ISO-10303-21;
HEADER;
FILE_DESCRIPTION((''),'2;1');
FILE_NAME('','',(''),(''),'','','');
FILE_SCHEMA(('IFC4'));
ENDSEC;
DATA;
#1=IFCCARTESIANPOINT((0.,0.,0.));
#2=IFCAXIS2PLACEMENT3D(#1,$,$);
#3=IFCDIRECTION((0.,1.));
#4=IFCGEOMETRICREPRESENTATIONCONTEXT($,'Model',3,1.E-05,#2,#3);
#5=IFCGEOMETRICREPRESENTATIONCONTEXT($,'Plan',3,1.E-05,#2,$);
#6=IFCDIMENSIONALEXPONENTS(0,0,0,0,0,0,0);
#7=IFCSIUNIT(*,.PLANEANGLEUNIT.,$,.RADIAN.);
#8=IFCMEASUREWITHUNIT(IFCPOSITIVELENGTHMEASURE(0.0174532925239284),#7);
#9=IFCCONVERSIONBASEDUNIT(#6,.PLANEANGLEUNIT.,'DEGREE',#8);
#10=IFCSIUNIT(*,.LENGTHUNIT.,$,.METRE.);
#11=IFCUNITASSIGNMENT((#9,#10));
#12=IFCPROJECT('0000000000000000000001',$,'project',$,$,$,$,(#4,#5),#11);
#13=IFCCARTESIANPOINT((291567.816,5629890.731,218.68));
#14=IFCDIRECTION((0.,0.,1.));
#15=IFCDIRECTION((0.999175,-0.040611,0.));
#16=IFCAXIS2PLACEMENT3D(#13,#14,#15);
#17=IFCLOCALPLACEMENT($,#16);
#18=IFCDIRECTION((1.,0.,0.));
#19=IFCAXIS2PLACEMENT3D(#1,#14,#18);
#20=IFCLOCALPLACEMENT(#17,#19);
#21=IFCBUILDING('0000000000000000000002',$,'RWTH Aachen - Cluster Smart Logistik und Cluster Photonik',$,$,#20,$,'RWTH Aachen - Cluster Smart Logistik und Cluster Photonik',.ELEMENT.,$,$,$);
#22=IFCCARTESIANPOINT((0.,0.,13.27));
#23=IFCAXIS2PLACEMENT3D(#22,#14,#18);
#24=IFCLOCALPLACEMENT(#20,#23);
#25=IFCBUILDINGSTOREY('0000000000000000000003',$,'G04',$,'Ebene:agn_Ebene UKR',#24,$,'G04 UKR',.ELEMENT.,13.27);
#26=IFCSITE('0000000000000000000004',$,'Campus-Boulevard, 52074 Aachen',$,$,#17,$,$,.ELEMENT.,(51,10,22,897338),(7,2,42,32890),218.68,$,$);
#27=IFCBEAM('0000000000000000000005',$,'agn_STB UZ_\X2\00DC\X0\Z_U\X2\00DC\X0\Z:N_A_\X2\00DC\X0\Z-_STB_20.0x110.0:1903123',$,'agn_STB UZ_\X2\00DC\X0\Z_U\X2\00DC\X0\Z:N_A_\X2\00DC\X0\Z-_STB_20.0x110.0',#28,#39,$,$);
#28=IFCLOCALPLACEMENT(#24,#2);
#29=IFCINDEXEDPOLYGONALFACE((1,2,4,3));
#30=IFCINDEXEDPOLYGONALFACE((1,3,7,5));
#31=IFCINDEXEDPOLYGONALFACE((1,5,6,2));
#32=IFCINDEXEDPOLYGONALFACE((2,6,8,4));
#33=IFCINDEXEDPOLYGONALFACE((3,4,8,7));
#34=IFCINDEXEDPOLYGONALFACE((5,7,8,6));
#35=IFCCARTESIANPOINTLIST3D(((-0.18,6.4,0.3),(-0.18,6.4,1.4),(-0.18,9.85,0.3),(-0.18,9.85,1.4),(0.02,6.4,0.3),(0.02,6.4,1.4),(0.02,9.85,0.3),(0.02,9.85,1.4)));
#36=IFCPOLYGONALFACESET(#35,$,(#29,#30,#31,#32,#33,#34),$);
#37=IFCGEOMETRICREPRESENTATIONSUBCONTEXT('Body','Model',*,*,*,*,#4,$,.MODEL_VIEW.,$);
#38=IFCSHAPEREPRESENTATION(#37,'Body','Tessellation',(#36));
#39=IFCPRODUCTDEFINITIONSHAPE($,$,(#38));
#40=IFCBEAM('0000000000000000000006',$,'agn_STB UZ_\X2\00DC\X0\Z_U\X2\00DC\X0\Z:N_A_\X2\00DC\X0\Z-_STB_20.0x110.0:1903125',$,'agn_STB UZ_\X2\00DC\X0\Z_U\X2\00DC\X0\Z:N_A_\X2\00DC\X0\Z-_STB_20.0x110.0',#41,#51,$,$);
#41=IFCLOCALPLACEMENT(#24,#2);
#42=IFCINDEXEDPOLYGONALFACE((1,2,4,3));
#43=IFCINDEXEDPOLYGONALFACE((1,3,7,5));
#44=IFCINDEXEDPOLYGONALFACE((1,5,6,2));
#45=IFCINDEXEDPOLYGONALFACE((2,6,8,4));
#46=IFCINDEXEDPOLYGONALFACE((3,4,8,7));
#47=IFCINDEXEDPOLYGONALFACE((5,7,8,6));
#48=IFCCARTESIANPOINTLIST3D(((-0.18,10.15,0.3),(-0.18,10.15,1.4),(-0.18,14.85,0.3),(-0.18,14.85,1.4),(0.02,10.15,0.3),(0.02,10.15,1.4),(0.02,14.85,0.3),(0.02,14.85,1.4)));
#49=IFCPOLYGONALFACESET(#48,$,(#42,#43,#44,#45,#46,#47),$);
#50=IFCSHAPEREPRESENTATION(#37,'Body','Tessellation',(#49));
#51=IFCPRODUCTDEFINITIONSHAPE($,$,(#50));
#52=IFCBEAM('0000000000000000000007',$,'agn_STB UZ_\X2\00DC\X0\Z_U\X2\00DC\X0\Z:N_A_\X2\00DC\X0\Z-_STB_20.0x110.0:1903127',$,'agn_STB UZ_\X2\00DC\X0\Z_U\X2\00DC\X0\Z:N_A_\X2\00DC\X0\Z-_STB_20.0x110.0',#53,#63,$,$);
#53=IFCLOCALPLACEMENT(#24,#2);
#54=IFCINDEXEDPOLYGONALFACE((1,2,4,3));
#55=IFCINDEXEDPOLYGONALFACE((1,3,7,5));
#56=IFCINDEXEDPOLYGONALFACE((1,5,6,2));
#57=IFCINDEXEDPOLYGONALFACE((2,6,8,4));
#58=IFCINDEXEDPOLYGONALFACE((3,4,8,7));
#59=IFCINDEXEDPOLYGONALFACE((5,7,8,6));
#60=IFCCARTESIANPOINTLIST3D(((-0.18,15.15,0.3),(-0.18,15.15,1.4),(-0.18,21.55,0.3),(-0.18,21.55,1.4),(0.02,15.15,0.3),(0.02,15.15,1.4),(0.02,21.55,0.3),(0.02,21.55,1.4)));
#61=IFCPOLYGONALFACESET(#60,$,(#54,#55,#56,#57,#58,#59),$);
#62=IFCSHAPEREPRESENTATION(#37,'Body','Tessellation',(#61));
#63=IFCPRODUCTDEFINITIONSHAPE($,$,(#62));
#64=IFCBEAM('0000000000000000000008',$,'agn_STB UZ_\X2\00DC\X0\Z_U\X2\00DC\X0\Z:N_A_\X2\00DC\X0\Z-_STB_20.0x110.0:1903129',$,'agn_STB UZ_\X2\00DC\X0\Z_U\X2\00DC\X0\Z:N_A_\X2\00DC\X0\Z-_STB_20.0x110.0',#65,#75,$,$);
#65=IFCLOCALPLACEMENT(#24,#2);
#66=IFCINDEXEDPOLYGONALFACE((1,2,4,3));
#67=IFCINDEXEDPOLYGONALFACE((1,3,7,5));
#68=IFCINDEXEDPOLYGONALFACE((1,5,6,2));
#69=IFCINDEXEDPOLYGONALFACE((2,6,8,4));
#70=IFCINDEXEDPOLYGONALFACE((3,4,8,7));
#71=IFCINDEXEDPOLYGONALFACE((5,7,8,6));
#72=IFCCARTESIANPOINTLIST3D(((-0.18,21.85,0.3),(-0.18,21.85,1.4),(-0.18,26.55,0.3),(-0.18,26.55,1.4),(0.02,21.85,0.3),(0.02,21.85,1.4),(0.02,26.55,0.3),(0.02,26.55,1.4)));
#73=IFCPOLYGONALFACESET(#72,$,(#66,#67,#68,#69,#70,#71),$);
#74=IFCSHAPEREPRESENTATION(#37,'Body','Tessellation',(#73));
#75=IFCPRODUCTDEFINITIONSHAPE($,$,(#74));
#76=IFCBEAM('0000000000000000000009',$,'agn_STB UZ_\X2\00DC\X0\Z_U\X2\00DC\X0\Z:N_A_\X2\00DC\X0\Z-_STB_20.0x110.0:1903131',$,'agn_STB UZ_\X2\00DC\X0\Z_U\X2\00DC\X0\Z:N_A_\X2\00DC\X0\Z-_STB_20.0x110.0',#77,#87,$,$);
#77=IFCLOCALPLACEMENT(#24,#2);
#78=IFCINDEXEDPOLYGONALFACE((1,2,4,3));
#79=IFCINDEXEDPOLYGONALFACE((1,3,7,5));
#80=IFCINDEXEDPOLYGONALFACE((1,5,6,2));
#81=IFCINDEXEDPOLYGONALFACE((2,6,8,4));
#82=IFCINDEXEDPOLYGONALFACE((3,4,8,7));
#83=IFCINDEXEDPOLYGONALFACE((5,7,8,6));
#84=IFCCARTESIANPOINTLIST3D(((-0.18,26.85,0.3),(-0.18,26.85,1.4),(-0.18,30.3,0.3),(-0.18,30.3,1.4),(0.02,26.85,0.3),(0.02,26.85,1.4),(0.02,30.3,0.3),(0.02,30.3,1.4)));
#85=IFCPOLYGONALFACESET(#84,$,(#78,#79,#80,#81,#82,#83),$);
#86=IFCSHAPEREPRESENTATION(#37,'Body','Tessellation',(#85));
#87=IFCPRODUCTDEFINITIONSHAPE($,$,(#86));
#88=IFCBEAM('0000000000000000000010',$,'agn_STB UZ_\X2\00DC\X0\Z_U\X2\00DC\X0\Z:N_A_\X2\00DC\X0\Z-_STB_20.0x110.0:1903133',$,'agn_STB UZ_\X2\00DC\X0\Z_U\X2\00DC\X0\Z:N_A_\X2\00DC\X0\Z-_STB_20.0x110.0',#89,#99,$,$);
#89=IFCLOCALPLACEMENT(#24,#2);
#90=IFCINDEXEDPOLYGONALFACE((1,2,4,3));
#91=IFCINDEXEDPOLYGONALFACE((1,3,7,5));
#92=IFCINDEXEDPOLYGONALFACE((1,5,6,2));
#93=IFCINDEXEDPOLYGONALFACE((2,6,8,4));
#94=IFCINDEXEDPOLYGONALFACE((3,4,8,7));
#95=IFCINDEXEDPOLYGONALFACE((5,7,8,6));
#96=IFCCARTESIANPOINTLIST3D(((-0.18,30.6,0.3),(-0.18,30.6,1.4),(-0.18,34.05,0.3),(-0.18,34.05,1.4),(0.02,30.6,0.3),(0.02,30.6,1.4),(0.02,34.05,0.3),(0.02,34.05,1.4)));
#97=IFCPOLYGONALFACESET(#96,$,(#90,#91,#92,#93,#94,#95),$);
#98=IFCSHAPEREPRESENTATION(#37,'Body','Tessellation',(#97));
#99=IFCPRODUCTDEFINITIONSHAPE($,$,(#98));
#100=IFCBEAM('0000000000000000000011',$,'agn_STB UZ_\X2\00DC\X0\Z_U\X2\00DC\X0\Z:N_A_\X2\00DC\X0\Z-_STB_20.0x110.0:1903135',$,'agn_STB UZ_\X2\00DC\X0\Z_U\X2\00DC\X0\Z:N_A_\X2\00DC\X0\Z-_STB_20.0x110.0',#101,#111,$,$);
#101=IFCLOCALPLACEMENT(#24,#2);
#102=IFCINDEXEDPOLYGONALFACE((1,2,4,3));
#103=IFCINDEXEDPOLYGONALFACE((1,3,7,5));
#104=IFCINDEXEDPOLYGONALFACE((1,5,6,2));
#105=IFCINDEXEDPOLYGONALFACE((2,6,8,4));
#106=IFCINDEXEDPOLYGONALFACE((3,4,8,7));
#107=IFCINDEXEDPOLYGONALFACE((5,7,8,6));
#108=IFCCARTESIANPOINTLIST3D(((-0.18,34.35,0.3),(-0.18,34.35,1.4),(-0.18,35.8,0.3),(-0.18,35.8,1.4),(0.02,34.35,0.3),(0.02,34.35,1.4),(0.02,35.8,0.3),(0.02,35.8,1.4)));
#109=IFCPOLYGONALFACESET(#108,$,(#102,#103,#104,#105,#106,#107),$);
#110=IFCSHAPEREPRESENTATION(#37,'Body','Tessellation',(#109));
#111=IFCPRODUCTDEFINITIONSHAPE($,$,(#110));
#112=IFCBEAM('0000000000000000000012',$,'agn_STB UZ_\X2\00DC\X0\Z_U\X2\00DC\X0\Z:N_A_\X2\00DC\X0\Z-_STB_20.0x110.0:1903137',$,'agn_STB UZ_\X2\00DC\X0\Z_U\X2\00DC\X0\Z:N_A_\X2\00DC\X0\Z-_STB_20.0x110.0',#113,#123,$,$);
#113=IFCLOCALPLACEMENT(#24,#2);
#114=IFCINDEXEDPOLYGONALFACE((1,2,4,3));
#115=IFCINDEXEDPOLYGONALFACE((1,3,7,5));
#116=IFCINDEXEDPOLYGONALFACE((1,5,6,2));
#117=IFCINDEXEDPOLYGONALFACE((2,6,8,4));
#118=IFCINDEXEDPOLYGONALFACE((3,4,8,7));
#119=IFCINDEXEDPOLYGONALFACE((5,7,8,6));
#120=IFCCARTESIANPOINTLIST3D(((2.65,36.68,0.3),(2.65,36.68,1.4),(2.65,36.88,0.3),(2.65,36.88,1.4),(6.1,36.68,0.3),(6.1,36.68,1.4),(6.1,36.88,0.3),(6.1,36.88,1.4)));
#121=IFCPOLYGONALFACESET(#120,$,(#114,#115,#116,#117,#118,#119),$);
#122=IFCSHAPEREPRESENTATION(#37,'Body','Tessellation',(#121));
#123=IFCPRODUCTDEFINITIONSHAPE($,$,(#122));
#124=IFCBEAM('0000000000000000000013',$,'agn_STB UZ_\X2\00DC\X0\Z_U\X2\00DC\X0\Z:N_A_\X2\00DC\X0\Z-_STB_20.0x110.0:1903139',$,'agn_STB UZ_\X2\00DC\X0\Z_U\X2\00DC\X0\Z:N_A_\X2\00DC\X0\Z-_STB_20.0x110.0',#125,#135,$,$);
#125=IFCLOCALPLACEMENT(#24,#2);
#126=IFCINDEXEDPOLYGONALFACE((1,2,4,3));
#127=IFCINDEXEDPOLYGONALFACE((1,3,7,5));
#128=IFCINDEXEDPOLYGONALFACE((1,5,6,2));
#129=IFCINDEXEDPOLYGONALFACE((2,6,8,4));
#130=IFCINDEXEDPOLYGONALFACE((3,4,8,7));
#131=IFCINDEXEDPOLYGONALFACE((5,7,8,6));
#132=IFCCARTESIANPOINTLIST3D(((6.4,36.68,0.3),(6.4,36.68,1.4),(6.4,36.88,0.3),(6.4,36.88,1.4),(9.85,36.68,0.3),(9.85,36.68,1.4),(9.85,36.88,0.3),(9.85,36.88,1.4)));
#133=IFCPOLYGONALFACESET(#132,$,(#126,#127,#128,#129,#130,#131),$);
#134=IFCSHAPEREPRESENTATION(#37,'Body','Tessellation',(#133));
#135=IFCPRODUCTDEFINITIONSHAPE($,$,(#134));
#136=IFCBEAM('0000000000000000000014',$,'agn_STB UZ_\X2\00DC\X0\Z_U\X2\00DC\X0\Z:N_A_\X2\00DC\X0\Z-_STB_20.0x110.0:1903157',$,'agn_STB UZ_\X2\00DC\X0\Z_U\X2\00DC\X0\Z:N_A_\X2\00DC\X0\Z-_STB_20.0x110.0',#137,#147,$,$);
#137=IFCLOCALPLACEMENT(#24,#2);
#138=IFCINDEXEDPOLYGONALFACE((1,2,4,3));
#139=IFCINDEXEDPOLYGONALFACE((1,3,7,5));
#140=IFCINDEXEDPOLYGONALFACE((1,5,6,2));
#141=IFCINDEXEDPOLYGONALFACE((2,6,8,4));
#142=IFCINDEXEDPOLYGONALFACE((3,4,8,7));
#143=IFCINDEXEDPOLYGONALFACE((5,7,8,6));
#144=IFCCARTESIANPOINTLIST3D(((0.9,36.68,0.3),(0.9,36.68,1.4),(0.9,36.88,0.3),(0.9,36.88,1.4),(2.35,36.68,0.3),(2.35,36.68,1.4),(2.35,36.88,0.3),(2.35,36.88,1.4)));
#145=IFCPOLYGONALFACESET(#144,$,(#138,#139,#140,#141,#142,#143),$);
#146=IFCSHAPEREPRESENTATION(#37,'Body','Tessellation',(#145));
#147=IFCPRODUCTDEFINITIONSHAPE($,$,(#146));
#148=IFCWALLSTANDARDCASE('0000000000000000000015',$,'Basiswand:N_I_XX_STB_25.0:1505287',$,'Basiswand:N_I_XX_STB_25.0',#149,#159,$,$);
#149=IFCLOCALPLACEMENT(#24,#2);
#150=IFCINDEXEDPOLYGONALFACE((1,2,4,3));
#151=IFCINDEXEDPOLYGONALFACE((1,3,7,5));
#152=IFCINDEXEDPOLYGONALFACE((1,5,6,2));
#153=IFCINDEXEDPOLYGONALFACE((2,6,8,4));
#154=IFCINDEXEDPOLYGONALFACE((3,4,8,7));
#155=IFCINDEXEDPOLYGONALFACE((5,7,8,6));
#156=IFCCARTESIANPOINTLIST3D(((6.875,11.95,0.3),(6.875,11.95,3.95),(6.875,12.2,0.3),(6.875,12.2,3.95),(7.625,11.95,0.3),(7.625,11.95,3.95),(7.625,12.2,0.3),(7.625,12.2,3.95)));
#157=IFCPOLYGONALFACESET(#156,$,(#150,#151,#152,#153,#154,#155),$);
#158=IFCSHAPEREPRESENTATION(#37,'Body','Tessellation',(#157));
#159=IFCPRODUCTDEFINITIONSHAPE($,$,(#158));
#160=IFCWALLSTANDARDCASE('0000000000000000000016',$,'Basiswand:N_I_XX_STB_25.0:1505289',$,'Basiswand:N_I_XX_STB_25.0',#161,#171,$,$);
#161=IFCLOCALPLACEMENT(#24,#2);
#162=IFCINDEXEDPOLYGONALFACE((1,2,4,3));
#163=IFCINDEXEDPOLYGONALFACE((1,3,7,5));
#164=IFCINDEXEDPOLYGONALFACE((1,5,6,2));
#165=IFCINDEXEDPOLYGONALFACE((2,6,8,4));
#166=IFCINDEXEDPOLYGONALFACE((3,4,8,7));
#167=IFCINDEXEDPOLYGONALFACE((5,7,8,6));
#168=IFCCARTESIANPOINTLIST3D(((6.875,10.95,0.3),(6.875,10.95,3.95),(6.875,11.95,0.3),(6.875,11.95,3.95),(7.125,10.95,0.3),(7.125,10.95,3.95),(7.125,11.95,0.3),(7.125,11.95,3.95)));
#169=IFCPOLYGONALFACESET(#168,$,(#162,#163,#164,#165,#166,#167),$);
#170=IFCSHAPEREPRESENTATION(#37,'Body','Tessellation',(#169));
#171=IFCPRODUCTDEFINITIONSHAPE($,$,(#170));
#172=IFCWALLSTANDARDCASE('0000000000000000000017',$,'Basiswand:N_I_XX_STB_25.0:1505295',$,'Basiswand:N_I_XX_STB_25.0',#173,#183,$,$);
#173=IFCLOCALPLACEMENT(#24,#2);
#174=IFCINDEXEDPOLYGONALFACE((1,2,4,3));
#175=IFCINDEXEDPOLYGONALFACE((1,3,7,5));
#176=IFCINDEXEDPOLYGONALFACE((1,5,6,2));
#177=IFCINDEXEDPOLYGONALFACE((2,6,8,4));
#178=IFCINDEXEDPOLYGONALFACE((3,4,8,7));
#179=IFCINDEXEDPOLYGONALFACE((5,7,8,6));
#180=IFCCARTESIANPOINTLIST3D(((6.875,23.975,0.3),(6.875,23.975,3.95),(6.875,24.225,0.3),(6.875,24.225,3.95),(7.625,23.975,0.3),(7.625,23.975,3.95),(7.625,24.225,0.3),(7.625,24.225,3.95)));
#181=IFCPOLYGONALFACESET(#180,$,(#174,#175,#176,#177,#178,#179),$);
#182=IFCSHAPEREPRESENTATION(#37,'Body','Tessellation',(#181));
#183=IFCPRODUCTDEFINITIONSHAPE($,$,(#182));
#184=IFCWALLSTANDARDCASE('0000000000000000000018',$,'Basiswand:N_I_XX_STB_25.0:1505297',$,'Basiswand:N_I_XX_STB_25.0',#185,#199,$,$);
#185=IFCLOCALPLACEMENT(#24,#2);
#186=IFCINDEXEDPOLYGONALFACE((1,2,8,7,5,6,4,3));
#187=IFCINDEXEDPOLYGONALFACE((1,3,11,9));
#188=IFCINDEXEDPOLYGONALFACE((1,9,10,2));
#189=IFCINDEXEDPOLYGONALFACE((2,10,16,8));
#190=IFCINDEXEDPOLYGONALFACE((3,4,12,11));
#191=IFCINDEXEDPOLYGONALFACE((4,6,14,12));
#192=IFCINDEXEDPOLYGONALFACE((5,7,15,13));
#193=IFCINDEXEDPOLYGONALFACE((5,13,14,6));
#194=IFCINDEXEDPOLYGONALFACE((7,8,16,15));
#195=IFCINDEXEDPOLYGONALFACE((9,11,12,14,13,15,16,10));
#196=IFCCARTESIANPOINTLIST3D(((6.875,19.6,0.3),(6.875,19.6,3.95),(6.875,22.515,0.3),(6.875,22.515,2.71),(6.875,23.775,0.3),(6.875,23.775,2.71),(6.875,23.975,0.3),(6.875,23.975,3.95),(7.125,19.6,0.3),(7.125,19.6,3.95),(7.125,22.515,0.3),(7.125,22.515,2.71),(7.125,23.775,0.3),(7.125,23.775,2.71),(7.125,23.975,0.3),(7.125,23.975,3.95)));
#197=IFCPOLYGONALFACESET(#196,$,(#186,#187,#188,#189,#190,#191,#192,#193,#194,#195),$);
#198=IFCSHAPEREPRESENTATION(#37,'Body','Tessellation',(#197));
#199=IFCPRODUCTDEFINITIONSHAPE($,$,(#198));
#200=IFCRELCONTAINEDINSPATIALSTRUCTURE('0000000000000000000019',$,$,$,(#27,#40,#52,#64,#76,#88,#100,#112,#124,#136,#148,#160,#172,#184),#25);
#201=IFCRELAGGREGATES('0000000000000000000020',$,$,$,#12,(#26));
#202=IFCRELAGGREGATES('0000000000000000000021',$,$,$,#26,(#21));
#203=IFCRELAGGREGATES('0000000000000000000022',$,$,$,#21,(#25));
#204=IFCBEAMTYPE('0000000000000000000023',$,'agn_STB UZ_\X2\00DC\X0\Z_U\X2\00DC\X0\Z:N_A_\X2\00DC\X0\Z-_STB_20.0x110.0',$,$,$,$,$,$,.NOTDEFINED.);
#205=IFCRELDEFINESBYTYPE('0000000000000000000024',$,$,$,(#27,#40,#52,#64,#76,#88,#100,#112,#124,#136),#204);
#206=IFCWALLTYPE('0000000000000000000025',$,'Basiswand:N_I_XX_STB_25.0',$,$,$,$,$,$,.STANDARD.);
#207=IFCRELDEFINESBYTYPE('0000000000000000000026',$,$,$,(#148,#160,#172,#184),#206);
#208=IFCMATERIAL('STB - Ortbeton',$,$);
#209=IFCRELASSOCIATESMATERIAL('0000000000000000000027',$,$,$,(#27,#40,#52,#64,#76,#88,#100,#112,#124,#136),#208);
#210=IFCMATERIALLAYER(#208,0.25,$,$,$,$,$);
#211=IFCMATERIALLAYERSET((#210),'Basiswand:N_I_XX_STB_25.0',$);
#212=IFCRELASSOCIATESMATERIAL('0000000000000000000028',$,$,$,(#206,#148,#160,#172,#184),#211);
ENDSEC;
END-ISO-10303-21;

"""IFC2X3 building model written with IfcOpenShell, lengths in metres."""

from ifc_helpers import new_model, entity, si_unit, converted_unit, direction, frame, frame_2d, origin, origin_with_axes, origin_2d_with_axis, place, context, subcontext, project, spatial, rectangle, extrude, material, layer, layer_set, layer_usage, type_object, element, save


model = new_model("IFC2X3")

# Units and contexts
model_context = context("Model", 3, precision=1e-05, world=origin(), true_north=direction((0.0, 1.0)))
plan_context = context("Plan", 3, precision=1e-05, world=origin())
body_context = subcontext(model_context, "Body", "Model", "MODEL_VIEW")
ifc_project = project(units=[converted_unit("PLANEANGLEUNIT", "DEGREE", entity("IfcPositiveLengthMeasure", 0.0174532925239284), si_unit("PLANEANGLEUNIT", "RADIAN"), dimensions=[0, 0, 0, 0, 0, 0, 0]), si_unit("LENGTHUNIT", "METRE")], contexts=[model_context, plan_context])

# Site, building, storey
site_placement = place(None, frame((291567.816, 5629890.731, 218.68), z_axis=(0.0, 0.0, 1.0), x_axis=(0.999175, -0.040611, 0.0)))
site = spatial("IfcSite", under=ifc_project, at=site_placement, Name="Campus-Boulevard, 52074 Aachen", CompositionType="ELEMENT", RefLatitude=(51, 10, 22, 897338), RefLongitude=(7, 2, 42, 32890), RefElevation=218.68)
building_placement = place(site_placement, origin_with_axes())
building = spatial("IfcBuilding", under=site, at=building_placement, Name="RWTH Aachen - Cluster Smart Logistik und Cluster Photonik", LongName="RWTH Aachen - Cluster Smart Logistik und Cluster Photonik", CompositionType="ELEMENT")
storey_placement = place(building_placement, frame((0.0, 0.0, 13.27), z_axis=(0.0, 0.0, 1.0), x_axis=(1.0, 0.0, 0.0)))
storey = spatial("IfcBuildingStorey", under=building, at=storey_placement, Name="G04", ObjectType="Ebene:agn_Ebene UKR", LongName="G04 UKR", CompositionType="ELEMENT", Elevation=13.27)

# Beams
ifc_material_1 = material(Name="STB - Ortbeton")
beam_type_1 = type_object("IfcBeamType", Name="agn_STB UZ_ÜZ_UÜZ:N_A_ÜZ-_STB_20.0x110.0", PredefinedType="NOTDEFINED")
beam_1_placement = place(storey_placement, frame((-0.08, 9.85, 0.3), z_axis=(0.0, 0.0, 1.0), x_axis=(0.0, -1.0, 0.0)))
element("IfcBeam", 1, at=beam_1_placement, inside=storey, type_object=beam_type_1, material=ifc_material_1, Name="agn_STB UZ_ÜZ_UÜZ:N_A_ÜZ-_STB_20.0x110.0:1903123", ObjectType="agn_STB UZ_ÜZ_UÜZ:N_A_ÜZ-_STB_20.0x110.0", context=body_context, shape_type="SweptSolid", body=[
    extrude(rectangle(XDim=1.1, YDim=0.2, at=frame_2d((0.0, 0.0), x_axis=(1.0, 0.0))), frame((0.0, 0.0, 0.55), z_axis=(1.0, 0.0, 0.0), x_axis=(0.0, 0.0, -1.0)), (0.0, 0.0, 1.0), 3.45),
])
beam_2_placement = place(storey_placement, frame((-0.08, 14.85, 0.3), z_axis=(0.0, 0.0, 1.0), x_axis=(0.0, -1.0, 0.0)))
element("IfcBeam", 2, at=beam_2_placement, inside=storey, type_object=beam_type_1, material=ifc_material_1, Name="agn_STB UZ_ÜZ_UÜZ:N_A_ÜZ-_STB_20.0x110.0:1903125", ObjectType="agn_STB UZ_ÜZ_UÜZ:N_A_ÜZ-_STB_20.0x110.0", context=body_context, shape_type="SweptSolid", body=[
    extrude(rectangle(XDim=1.1, YDim=0.2, at=frame_2d((0.0, 0.0), x_axis=(1.0, 0.0))), frame((0.0, 0.0, 0.55), z_axis=(1.0, 0.0, 0.0), x_axis=(0.0, 0.0, -1.0)), (0.0, 0.0, 1.0), 4.7),
])
beam_3_placement = place(storey_placement, frame((-0.08, 21.55, 0.3), z_axis=(0.0, 0.0, 1.0), x_axis=(0.0, -1.0, 0.0)))
element("IfcBeam", 3, at=beam_3_placement, inside=storey, type_object=beam_type_1, material=ifc_material_1, Name="agn_STB UZ_ÜZ_UÜZ:N_A_ÜZ-_STB_20.0x110.0:1903127", ObjectType="agn_STB UZ_ÜZ_UÜZ:N_A_ÜZ-_STB_20.0x110.0", context=body_context, shape_type="SweptSolid", body=[
    extrude(rectangle(XDim=1.1, YDim=0.2, at=origin_2d_with_axis()), frame((0.0, 0.0, 0.55), z_axis=(1.0, 0.0, 0.0), x_axis=(0.0, 0.0, -1.0)), (0.0, 0.0, 1.0), 6.4),
])
beam_4_placement = place(storey_placement, frame((-0.08, 26.55, 0.3), z_axis=(0.0, 0.0, 1.0), x_axis=(0.0, -1.0, 0.0)))
element("IfcBeam", 4, at=beam_4_placement, inside=storey, type_object=beam_type_1, material=ifc_material_1, Name="agn_STB UZ_ÜZ_UÜZ:N_A_ÜZ-_STB_20.0x110.0:1903129", ObjectType="agn_STB UZ_ÜZ_UÜZ:N_A_ÜZ-_STB_20.0x110.0", context=body_context, shape_type="SweptSolid", body=[
    extrude(rectangle(XDim=1.1, YDim=0.2, at=frame_2d((0.0, 0.0), x_axis=(1.0, 0.0))), frame((0.0, 0.0, 0.55), z_axis=(1.0, 0.0, 0.0), x_axis=(0.0, 0.0, -1.0)), (0.0, 0.0, 1.0), 4.7),
])
for number, where, z_axis, x_axis, name in (
    (5, (-0.08, 30.3, 0.3), (0.0, 0.0, 1.0), (0.0, -1.0, 0.0), "agn_STB UZ_ÜZ_UÜZ:N_A_ÜZ-_STB_20.0x110.0:1903131"),
    (6, (-0.08, 34.05, 0.3), (0.0, 0.0, 1.0), (0.0, -1.0, 0.0), "agn_STB UZ_ÜZ_UÜZ:N_A_ÜZ-_STB_20.0x110.0:1903133"),
):
    element("IfcBeam", number, at=place(storey_placement, frame(where, z_axis=z_axis, x_axis=x_axis)), inside=storey, type_object=beam_type_1, material=ifc_material_1, Name=name, ObjectType="agn_STB UZ_ÜZ_UÜZ:N_A_ÜZ-_STB_20.0x110.0", context=body_context, shape_type="SweptSolid", body=[
        extrude(rectangle(XDim=1.1, YDim=0.2, at=frame_2d((0.0, 0.0), x_axis=(1.0, 0.0))), frame((0.0, 0.0, 0.55), z_axis=(1.0, 0.0, 0.0), x_axis=(0.0, 0.0, -1.0)), (0.0, 0.0, 1.0), 3.45),
    ])
beam_5_placement = place(storey_placement, frame((-0.08, 35.8, 0.3), z_axis=(0.0, 0.0, 1.0), x_axis=(0.0, -1.0, 0.0)))
element("IfcBeam", 7, at=beam_5_placement, inside=storey, type_object=beam_type_1, material=ifc_material_1, Name="agn_STB UZ_ÜZ_UÜZ:N_A_ÜZ-_STB_20.0x110.0:1903135", ObjectType="agn_STB UZ_ÜZ_UÜZ:N_A_ÜZ-_STB_20.0x110.0", context=body_context, shape_type="SweptSolid", body=[
    extrude(rectangle(XDim=1.1, YDim=0.2, at=frame_2d((0.0, 0.0), x_axis=(1.0, 0.0))), frame((0.0, 0.0, 0.55), z_axis=(1.0, 0.0, 0.0), x_axis=(0.0, 0.0, -1.0)), (0.0, 0.0, 1.0), 1.45),
])
for number, where, z_axis, x_axis, name in (
    (8, (2.65, 36.78, 0.3), (0.0, 0.0, 1.0), (1.0, 0.0, 0.0), "agn_STB UZ_ÜZ_UÜZ:N_A_ÜZ-_STB_20.0x110.0:1903137"),
    (9, (6.4, 36.78, 0.3), (0.0, 0.0, 1.0), (1.0, 0.0, 0.0), "agn_STB UZ_ÜZ_UÜZ:N_A_ÜZ-_STB_20.0x110.0:1903139"),
):
    element("IfcBeam", number, at=place(storey_placement, frame(where, z_axis=z_axis, x_axis=x_axis)), inside=storey, type_object=beam_type_1, material=ifc_material_1, Name=name, ObjectType="agn_STB UZ_ÜZ_UÜZ:N_A_ÜZ-_STB_20.0x110.0", context=body_context, shape_type="SweptSolid", body=[
        extrude(rectangle(XDim=1.1, YDim=0.2, at=frame_2d((0.0, 0.0), x_axis=(1.0, 0.0))), frame((0.0, 0.0, 0.55), z_axis=(1.0, 0.0, 0.0), x_axis=(0.0, 0.0, -1.0)), (0.0, 0.0, 1.0), 3.45),
    ])
beam_6_placement = place(storey_placement, frame((0.9, 36.78, 0.3), z_axis=(0.0, 0.0, 1.0), x_axis=(1.0, 0.0, 0.0)))
element("IfcBeam", 10, at=beam_6_placement, inside=storey, type_object=beam_type_1, material=ifc_material_1, Name="agn_STB UZ_ÜZ_UÜZ:N_A_ÜZ-_STB_20.0x110.0:1903157", ObjectType="agn_STB UZ_ÜZ_UÜZ:N_A_ÜZ-_STB_20.0x110.0", context=body_context, shape_type="SweptSolid", body=[
    extrude(rectangle(XDim=1.1, YDim=0.2, at=frame_2d((0.0, 0.0), x_axis=(1.0, 0.0))), frame((0.0, 0.0, 0.55), z_axis=(1.0, 0.0, 0.0), x_axis=(0.0, 0.0, -1.0)), (0.0, 0.0, 1.0), 1.45),
])

# Shared definitions
ifc_layer = layer(ifc_material_1, 0.25)
ifc_layer_set = layer_set([ifc_layer], Name="Basiswand:N_I_XX_STB_25.0")
wall_type = type_object("IfcWallType", Name="Basiswand:N_I_XX_STB_25.0", PredefinedType="STANDARD", material=ifc_layer_set)

# Walls
ifc_layer_usage_1 = layer_usage(ifc_layer_set, "AXIS2", "NEGATIVE", 0.125)
wall_1_placement = place(storey_placement, frame((6.875, 12.075, 0.3), z_axis=(0.0, 0.0, 1.0), x_axis=(1.0, 0.0, 0.0)))
element("IfcWallStandardCase", 11, at=wall_1_placement, inside=storey, type_object=wall_type, material=ifc_layer_usage_1, Name="Basiswand:N_I_XX_STB_25.0:1505287", ObjectType="Basiswand:N_I_XX_STB_25.0", context=body_context, shape_type="SweptSolid", body=[
    extrude(rectangle(XDim=0.75, YDim=0.25, at=frame_2d((0.375, 0.0), x_axis=(-1.0, 0.0))), origin(), (0.0, 0.0, 1.0), 3.65),
])
ifc_layer_usage_2 = layer_usage(ifc_layer_set, "AXIS2", "NEGATIVE", 0.125)
wall_2_placement = place(storey_placement, frame((7.0, 11.95, 0.3), z_axis=(0.0, 0.0, 1.0), x_axis=(0.0, -1.0, 0.0)))
element("IfcWallStandardCase", 12, at=wall_2_placement, inside=storey, type_object=wall_type, material=ifc_layer_usage_2, Name="Basiswand:N_I_XX_STB_25.0:1505289", ObjectType="Basiswand:N_I_XX_STB_25.0", context=body_context, shape_type="SweptSolid", body=[
    extrude(rectangle(XDim=1.0, YDim=0.25, at=frame_2d((0.5, 0.0), x_axis=(-1.0, 0.0))), origin(), (0.0, 0.0, 1.0), 3.65),
])
ifc_layer_usage_3 = layer_usage(ifc_layer_set, "AXIS2", "NEGATIVE", 0.125)
wall_3_placement = place(storey_placement, frame((6.875, 24.1, 0.3), z_axis=(0.0, 0.0, 1.0), x_axis=(1.0, 0.0, 0.0)))
element("IfcWallStandardCase", 13, at=wall_3_placement, inside=storey, type_object=wall_type, material=ifc_layer_usage_3, Name="Basiswand:N_I_XX_STB_25.0:1505295", ObjectType="Basiswand:N_I_XX_STB_25.0", context=body_context, shape_type="SweptSolid", body=[
    extrude(rectangle(XDim=0.75, YDim=0.25, at=frame_2d((0.375, 0.0), x_axis=(-1.0, 0.0))), origin(), (0.0, 0.0, 1.0), 3.65),
])

# Wall, opening
ifc_layer_usage_4 = layer_usage(ifc_layer_set, "AXIS2", "NEGATIVE", 0.125)
wall_4_placement = place(storey_placement, frame((7.0, 19.6, 0.3), z_axis=(0.0, 0.0, 1.0), x_axis=(0.0, 1.0, 0.0)))
wall_4 = element("IfcWallStandardCase", 14, at=wall_4_placement, inside=storey, type_object=wall_type, material=ifc_layer_usage_4, Name="Basiswand:N_I_XX_STB_25.0:1505297", ObjectType="Basiswand:N_I_XX_STB_25.0", context=body_context, shape_type="SweptSolid", body=[
    extrude(rectangle(XDim=4.375, YDim=0.25, at=frame_2d((2.1875, 0.0), x_axis=(-1.0, 0.0))), origin(), (0.0, 0.0, 1.0), 3.65),
])
opening_1_placement = place(wall_4_placement, frame((4.175, 0.125, 0.0), z_axis=(0.0, 0.0, 1.0), x_axis=(1.0, 0.0, 0.0)))
element("IfcOpeningElement", 15, at=opening_1_placement, cuts=wall_4, ObjectType="Opening", context=body_context, shape_type="SweptSolid", body=[
    extrude(rectangle(XDim=2.41, YDim=1.26, at=frame_2d((1.205, 0.63), x_axis=(1.0, 0.0))), frame((0.0, 0.0, 0.0), z_axis=(0.0, -1.0, 0.0), x_axis=(0.0, 0.0, 1.0)), (0.0, 0.0, 1.0), 0.25),
])

save(model, "model.ifc")
